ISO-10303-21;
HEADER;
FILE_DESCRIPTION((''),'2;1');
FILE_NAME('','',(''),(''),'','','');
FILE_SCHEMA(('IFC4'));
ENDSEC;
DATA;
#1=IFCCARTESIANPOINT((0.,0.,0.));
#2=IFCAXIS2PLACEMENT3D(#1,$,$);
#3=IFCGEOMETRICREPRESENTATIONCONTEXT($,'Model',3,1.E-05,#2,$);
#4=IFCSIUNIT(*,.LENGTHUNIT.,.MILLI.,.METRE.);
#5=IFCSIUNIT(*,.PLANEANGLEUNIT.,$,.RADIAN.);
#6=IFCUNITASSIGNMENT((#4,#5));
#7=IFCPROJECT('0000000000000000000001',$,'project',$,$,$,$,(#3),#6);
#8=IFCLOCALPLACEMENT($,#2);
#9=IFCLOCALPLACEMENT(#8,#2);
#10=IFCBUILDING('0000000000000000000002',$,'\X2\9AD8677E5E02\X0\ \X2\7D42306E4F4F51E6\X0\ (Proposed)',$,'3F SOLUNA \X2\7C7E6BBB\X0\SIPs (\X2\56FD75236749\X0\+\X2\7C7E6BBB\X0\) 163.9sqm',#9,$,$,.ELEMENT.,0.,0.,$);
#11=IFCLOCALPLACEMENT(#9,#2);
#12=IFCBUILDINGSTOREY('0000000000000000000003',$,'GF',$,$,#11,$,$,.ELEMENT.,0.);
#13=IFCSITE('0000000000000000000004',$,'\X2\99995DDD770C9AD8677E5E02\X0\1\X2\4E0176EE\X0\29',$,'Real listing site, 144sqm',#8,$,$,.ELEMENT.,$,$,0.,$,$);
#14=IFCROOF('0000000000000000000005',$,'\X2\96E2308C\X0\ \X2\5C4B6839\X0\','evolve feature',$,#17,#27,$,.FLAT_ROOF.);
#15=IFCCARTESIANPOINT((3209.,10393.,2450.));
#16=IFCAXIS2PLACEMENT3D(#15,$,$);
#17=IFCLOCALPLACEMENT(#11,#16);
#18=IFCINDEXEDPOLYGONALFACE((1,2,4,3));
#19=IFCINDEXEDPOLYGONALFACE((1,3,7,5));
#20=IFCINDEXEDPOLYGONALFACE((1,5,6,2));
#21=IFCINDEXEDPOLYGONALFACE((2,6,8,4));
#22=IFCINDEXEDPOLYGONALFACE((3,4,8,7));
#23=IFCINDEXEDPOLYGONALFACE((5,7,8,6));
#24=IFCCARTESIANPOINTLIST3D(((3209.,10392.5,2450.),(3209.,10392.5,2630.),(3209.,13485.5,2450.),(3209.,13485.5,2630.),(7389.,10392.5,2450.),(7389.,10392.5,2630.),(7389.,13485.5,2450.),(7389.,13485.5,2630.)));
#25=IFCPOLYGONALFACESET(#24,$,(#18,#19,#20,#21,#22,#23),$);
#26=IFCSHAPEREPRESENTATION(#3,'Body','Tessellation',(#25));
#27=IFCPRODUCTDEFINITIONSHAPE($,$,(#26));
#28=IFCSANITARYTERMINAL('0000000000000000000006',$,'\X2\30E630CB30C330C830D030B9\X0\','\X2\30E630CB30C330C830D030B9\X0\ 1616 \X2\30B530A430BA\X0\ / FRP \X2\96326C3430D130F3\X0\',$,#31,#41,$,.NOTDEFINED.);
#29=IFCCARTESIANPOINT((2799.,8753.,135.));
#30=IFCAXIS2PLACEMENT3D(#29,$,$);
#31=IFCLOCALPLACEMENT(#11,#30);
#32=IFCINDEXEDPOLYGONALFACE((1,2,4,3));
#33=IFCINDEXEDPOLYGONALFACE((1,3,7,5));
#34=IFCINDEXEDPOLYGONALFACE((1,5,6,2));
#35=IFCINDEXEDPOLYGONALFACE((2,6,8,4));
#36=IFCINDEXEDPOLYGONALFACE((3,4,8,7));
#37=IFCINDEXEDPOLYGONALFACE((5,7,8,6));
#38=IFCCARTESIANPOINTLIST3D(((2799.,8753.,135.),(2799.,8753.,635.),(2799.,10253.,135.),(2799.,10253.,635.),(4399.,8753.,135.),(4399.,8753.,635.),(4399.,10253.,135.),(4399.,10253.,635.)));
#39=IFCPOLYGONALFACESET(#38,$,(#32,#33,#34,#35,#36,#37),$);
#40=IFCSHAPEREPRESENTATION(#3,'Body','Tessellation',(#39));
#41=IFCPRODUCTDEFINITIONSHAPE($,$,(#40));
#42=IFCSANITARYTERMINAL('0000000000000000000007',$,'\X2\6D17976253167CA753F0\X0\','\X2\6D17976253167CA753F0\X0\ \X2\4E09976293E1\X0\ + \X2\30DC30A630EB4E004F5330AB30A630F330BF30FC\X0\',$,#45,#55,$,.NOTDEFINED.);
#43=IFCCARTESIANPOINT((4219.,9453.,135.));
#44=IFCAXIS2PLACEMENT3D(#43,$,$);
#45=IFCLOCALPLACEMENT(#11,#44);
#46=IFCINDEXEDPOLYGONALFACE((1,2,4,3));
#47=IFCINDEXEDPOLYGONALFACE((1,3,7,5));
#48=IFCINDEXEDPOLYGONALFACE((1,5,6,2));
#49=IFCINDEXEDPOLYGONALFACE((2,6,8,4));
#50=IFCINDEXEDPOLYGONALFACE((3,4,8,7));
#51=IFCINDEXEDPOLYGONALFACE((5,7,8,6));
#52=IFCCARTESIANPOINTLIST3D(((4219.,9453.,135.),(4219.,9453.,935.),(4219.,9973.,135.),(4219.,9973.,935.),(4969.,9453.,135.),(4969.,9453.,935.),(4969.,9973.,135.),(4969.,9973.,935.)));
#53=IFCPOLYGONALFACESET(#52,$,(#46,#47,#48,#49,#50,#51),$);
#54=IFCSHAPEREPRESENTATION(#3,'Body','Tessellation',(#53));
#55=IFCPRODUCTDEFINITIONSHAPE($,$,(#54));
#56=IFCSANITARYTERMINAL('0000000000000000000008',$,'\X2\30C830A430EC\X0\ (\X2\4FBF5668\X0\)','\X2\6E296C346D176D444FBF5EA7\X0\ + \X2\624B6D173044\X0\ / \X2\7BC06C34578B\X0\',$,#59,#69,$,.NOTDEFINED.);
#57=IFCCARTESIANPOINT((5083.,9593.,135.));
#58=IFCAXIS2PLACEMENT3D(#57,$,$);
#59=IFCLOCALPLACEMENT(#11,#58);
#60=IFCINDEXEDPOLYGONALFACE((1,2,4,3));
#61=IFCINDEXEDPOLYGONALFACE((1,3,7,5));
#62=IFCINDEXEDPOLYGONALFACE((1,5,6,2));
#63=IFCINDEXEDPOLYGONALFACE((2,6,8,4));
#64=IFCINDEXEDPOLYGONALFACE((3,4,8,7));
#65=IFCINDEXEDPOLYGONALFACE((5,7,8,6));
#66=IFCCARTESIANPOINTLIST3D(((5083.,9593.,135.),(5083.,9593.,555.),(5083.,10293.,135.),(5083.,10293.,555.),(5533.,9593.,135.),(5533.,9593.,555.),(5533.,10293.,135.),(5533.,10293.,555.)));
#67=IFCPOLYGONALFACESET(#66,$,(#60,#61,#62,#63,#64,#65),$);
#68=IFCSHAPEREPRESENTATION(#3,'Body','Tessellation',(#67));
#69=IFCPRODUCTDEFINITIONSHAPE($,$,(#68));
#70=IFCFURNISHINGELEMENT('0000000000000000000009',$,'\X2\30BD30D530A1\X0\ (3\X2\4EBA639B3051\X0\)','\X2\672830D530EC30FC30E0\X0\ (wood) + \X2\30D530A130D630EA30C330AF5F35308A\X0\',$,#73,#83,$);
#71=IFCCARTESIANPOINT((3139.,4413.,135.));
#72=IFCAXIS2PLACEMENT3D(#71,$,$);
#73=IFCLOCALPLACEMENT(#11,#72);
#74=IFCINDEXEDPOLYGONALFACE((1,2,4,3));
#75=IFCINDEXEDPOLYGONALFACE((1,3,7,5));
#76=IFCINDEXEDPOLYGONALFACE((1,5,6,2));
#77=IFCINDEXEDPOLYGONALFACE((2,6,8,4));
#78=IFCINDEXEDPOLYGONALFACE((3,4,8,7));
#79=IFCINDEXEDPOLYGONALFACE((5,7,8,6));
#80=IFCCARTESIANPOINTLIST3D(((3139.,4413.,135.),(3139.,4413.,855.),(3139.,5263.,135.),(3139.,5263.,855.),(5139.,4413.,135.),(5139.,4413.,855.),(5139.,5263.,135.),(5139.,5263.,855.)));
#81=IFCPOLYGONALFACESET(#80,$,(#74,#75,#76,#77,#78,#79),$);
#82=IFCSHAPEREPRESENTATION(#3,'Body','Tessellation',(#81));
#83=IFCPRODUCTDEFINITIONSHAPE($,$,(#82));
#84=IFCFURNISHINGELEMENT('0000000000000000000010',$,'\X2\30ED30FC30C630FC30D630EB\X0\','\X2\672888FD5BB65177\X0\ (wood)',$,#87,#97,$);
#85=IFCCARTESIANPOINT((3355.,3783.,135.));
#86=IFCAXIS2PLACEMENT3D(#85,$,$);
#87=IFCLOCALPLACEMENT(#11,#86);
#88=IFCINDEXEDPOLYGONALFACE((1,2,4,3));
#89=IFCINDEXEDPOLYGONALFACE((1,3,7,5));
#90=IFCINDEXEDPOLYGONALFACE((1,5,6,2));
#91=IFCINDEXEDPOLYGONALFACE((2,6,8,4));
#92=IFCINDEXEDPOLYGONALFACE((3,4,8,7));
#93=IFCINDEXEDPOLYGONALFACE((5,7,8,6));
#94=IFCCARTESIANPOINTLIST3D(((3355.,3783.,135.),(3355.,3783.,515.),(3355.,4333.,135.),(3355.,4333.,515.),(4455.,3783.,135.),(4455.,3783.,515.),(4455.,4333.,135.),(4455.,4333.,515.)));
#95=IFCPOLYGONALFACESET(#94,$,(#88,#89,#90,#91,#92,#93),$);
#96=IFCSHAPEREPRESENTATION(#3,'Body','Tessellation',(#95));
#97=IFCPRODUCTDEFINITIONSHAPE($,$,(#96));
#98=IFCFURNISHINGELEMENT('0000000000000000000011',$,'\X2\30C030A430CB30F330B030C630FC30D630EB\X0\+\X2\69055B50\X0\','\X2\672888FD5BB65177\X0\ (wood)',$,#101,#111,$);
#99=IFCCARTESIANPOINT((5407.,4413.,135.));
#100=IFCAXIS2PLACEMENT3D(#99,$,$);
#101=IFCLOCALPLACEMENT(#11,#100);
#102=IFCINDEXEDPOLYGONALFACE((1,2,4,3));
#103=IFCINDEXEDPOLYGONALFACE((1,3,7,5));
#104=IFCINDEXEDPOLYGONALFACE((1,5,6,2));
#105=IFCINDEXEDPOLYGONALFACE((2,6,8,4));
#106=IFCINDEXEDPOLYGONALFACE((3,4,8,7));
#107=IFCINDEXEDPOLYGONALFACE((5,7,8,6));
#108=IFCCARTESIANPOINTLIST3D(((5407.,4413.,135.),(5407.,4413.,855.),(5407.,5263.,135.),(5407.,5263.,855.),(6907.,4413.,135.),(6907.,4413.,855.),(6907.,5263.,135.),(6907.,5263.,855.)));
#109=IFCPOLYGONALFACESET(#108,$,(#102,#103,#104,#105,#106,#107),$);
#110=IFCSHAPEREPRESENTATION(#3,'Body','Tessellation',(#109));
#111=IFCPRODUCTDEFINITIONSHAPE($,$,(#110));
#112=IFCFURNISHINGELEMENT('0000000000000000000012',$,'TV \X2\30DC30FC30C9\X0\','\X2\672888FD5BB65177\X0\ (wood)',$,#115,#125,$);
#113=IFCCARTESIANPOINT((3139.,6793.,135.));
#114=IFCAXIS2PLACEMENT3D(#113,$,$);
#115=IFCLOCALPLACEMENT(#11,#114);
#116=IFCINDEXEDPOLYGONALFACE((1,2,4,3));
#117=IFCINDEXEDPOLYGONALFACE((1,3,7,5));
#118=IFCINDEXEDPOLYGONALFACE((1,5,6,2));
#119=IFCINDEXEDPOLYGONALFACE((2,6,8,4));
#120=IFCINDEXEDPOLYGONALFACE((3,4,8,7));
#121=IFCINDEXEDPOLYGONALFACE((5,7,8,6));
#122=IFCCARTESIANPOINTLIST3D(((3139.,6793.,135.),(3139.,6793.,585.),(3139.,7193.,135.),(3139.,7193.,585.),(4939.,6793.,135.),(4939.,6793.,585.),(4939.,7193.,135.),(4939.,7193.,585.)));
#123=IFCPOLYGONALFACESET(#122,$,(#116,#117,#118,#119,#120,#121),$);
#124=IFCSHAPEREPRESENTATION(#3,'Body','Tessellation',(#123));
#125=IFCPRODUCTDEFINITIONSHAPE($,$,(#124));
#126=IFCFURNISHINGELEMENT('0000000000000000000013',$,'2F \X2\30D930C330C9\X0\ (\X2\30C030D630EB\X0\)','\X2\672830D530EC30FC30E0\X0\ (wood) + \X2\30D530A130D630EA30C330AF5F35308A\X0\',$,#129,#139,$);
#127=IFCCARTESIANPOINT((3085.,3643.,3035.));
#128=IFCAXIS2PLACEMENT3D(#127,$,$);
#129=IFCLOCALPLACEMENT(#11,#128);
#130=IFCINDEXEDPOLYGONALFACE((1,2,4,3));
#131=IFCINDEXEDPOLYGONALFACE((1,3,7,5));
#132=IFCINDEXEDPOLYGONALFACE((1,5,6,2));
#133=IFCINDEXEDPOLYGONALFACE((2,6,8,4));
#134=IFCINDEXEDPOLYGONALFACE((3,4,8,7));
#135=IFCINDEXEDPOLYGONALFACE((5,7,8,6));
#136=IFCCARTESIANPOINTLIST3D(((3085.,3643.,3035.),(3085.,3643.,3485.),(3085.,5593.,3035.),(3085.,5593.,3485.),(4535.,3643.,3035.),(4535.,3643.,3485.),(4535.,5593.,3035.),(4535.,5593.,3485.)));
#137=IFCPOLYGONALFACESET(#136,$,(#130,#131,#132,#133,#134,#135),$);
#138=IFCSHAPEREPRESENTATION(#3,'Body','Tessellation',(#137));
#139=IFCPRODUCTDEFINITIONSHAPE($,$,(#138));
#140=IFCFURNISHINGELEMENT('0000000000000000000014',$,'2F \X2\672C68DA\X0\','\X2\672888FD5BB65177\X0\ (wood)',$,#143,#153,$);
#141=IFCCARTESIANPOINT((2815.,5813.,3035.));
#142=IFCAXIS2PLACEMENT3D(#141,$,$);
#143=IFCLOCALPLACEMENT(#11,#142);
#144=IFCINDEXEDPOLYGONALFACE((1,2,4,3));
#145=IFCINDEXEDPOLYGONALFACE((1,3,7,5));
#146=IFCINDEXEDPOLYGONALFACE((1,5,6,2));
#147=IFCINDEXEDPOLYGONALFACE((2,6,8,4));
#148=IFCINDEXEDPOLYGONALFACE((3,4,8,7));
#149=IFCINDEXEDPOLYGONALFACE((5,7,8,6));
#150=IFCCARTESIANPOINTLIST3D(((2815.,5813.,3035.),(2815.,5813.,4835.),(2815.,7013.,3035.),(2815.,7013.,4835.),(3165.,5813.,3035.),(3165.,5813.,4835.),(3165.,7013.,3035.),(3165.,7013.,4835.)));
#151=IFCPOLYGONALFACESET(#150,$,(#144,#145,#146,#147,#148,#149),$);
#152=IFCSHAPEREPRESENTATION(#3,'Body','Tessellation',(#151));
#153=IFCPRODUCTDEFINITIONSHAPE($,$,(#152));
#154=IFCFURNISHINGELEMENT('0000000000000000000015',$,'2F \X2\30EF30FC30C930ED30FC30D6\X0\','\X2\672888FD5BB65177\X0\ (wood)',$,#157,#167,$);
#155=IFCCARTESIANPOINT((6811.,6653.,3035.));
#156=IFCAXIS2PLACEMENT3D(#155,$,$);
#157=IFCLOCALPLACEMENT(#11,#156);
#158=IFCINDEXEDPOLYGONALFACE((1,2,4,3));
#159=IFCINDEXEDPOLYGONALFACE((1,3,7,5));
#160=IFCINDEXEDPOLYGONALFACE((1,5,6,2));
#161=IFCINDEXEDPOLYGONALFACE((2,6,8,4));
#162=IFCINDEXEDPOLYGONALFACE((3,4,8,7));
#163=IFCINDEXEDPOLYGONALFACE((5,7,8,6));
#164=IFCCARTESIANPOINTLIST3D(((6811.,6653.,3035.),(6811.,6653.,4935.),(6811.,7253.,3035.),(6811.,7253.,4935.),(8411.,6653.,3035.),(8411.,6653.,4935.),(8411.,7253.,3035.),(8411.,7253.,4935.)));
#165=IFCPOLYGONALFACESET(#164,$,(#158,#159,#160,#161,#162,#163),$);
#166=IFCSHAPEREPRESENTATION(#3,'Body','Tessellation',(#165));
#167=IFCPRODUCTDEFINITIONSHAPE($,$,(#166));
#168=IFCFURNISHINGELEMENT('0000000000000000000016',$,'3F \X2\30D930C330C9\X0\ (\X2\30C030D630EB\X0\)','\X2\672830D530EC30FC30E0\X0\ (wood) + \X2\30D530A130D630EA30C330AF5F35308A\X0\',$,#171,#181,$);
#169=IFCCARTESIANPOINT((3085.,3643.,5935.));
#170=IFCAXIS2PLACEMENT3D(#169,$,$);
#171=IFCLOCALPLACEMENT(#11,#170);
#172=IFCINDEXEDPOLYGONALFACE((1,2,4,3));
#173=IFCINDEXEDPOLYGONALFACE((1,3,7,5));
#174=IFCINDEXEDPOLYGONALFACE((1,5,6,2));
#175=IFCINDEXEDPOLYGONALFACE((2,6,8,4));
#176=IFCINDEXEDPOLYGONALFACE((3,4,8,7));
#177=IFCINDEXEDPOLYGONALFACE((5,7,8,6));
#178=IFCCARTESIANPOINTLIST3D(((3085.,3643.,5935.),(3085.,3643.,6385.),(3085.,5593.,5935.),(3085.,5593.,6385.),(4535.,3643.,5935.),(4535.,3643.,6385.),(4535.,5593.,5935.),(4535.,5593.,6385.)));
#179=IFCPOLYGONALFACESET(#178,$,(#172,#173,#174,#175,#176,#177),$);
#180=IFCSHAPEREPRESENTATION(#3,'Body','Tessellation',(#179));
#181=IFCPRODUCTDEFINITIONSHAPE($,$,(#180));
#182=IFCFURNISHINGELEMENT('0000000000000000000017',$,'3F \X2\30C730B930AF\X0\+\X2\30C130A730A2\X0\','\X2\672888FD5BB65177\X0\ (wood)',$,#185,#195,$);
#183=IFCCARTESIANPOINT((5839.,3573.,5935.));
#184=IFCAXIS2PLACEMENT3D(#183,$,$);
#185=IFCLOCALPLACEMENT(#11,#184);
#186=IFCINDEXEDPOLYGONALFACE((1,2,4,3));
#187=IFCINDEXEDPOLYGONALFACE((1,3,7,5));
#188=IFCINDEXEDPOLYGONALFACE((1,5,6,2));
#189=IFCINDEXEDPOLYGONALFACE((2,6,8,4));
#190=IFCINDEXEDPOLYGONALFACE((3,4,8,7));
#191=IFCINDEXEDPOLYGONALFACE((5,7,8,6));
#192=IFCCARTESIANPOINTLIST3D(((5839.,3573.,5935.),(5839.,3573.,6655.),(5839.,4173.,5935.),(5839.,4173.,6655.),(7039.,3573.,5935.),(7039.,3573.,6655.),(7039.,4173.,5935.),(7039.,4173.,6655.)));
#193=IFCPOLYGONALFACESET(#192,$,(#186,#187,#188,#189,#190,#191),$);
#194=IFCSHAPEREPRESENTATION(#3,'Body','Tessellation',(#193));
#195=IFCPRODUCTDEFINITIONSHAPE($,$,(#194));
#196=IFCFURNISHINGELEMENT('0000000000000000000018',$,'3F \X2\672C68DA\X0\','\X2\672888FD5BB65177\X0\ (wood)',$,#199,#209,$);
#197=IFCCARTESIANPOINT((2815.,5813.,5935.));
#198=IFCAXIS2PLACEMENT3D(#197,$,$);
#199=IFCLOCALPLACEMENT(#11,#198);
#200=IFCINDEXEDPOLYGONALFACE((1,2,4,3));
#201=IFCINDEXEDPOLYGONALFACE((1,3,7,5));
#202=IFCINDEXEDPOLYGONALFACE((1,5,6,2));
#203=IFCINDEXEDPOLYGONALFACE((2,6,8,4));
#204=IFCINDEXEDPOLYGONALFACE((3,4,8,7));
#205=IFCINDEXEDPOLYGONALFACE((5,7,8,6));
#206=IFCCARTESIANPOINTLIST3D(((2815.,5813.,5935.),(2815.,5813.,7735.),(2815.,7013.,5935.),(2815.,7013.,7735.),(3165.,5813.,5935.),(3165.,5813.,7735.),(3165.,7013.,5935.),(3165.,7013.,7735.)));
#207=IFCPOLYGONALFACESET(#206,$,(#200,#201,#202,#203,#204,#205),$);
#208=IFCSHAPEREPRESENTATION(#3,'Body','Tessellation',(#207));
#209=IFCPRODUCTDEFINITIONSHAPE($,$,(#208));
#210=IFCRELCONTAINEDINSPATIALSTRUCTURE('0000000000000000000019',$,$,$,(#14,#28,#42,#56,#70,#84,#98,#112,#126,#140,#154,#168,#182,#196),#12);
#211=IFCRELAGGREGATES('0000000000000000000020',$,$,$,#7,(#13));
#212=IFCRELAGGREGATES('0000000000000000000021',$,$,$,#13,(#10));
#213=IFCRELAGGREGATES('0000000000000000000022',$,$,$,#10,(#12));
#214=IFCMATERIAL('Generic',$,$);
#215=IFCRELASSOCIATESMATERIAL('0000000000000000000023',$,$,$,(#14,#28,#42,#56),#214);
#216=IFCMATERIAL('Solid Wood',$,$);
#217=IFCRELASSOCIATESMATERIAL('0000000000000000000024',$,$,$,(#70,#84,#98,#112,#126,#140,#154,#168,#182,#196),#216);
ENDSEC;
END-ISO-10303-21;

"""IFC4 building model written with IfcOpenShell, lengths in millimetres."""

from ifc_helpers import new_model, si_unit, frame, frame_2d, origin, place, context, project, spatial, rectangle, extrude, material, element, save


model = new_model("IFC4")

# Units and contexts
model_context = context("Model", 3, precision=1e-05, world=origin())
ifc_project = project(units=[si_unit("LENGTHUNIT", "METRE", prefix="MILLI"), si_unit("PLANEANGLEUNIT", "RADIAN")], contexts=[model_context])

# Site, building, storey
site_placement = place(None, origin())
site = spatial("IfcSite", under=ifc_project, at=site_placement, Name="香川県高松市1丁目29", ObjectType="Real listing site, 144sqm", CompositionType="ELEMENT", RefElevation=0.0)
building_placement = place(site_placement, origin())
building = spatial("IfcBuilding", under=site, at=building_placement, Name="高松市 終の住処 (Proposed)", ObjectType="3F SOLUNA 籾殻SIPs (国産杉+籾殻) 163.9sqm", CompositionType="ELEMENT", ElevationOfRefHeight=0.0, ElevationOfTerrain=0.0)
storey_placement = place(building_placement, origin())
storey = spatial("IfcBuildingStorey", under=building, at=storey_placement, Name="GF", CompositionType="ELEMENT", Elevation=0.0)

# Shared definitions
ifc_material_1 = material(Name="Generic")

# Shared definitions
ifc_material_2 = material(Name="Solid Wood")

# Roof
roof_placement = place(storey_placement, frame((3209.0, 10393.0, 2450.0)))
element("IfcRoof", 1, at=roof_placement, inside=storey, material=ifc_material_1, Name="離れ 屋根", Description="evolve feature", PredefinedType="FLAT_ROOF", context=model_context, shape_type="SweptSolid", body=[
    extrude(rectangle(XDim=4180.0, YDim=3093.0, at=frame_2d((2090.0, 1546.0))), frame((3209.0, 10393.0, 2450.0)), (0.0, 0.0, 1.0), 180.0),
])

# Sanitary terminals
sanitary_terminal_1_placement = place(storey_placement, frame((2799.0, 8753.0, 135.0)))
element("IfcSanitaryTerminal", 2, at=sanitary_terminal_1_placement, inside=storey, material=ifc_material_1, Name="ユニットバス", Description="ユニットバス 1616 サイズ / FRP 防水パン", PredefinedType="NOTDEFINED", context=model_context, shape_type="SweptSolid", body=[
    extrude(rectangle(XDim=1600.0, YDim=1500.0, at=frame_2d((800.0, 750.0))), frame((2799.0, 8753.0, 135.0)), (0.0, 0.0, 1.0), 500.0),
])
sanitary_terminal_2_placement = place(storey_placement, frame((4219.0, 9453.0, 135.0)))
element("IfcSanitaryTerminal", 3, at=sanitary_terminal_2_placement, inside=storey, material=ifc_material_1, Name="洗面化粧台", Description="洗面化粧台 三面鏡 + ボウル一体カウンター", PredefinedType="NOTDEFINED", context=model_context, shape_type="SweptSolid", body=[
    extrude(rectangle(XDim=750.0, YDim=520.0, at=frame_2d((375.0, 260.0))), frame((4219.0, 9453.0, 135.0)), (0.0, 0.0, 1.0), 800.0),
])
sanitary_terminal_3_placement = place(storey_placement, frame((5083.0, 9593.0, 135.0)))
element("IfcSanitaryTerminal", 4, at=sanitary_terminal_3_placement, inside=storey, material=ifc_material_1, Name="トイレ (便器)", Description="温水洗浄便座 + 手洗い / 節水型", PredefinedType="NOTDEFINED", context=model_context, shape_type="SweptSolid", body=[
    extrude(rectangle(XDim=450.0, YDim=700.0, at=frame_2d((225.0, 350.0))), frame((5083.0, 9593.0, 135.0)), (0.0, 0.0, 1.0), 420.0),
])

# Furnishing elements
furnishing_1_placement = place(storey_placement, frame((3139.0, 4413.0, 135.0)))
element("IfcFurnishingElement", 5, at=furnishing_1_placement, inside=storey, material=ifc_material_2, Name="ソファ (3人掛け)", Description="木フレーム (wood) + ファブリック張り", context=model_context, shape_type="SweptSolid", body=[
    extrude(rectangle(XDim=2000.0, YDim=850.0, at=frame_2d((1000.0, 425.0))), frame((3139.0, 4413.0, 135.0)), (0.0, 0.0, 1.0), 720.0),
])
furnishing_2_placement = place(storey_placement, frame((3355.0, 3783.0, 135.0)))
element("IfcFurnishingElement", 6, at=furnishing_2_placement, inside=storey, material=ifc_material_2, Name="ローテーブル", Description="木製家具 (wood)", context=model_context, shape_type="SweptSolid", body=[
    extrude(rectangle(XDim=1100.0, YDim=550.0, at=frame_2d((550.0, 275.0))), frame((3355.0, 3783.0, 135.0)), (0.0, 0.0, 1.0), 380.0),
])
furnishing_3_placement = place(storey_placement, frame((5407.0, 4413.0, 135.0)))
element("IfcFurnishingElement", 7, at=furnishing_3_placement, inside=storey, material=ifc_material_2, Name="ダイニングテーブル+椅子", Description="木製家具 (wood)", context=model_context, shape_type="SweptSolid", body=[
    extrude(rectangle(XDim=1500.0, YDim=850.0, at=frame_2d((750.0, 425.0))), frame((5407.0, 4413.0, 135.0)), (0.0, 0.0, 1.0), 720.0),
])
furnishing_4_placement = place(storey_placement, frame((3139.0, 6793.0, 135.0)))
element("IfcFurnishingElement", 8, at=furnishing_4_placement, inside=storey, material=ifc_material_2, Name="TV ボード", Description="木製家具 (wood)", context=model_context, shape_type="SweptSolid", body=[
    extrude(rectangle(XDim=1800.0, YDim=400.0, at=frame_2d((900.0, 200.0))), frame((3139.0, 6793.0, 135.0)), (0.0, 0.0, 1.0), 450.0),
])
furnishing_5_placement = place(storey_placement, frame((3085.0, 3643.0, 3035.0)))
element("IfcFurnishingElement", 9, at=furnishing_5_placement, inside=storey, material=ifc_material_2, Name="2F ベッド (ダブル)", Description="木フレーム (wood) + ファブリック張り", context=model_context, shape_type="SweptSolid", body=[
    extrude(rectangle(XDim=1450.0, YDim=1950.0, at=frame_2d((725.0, 975.0))), frame((3085.0, 3643.0, 3035.0)), (0.0, 0.0, 1.0), 450.0),
])
furnishing_6_placement = place(storey_placement, frame((2815.0, 5813.0, 3035.0)))
element("IfcFurnishingElement", 10, at=furnishing_6_placement, inside=storey, material=ifc_material_2, Name="2F 本棚", Description="木製家具 (wood)", context=model_context, shape_type="SweptSolid", body=[
    extrude(rectangle(XDim=350.0, YDim=1200.0, at=frame_2d((175.0, 600.0))), frame((2815.0, 5813.0, 3035.0)), (0.0, 0.0, 1.0), 1800.0),
])
furnishing_7_placement = place(storey_placement, frame((6811.0, 6653.0, 3035.0)))
element("IfcFurnishingElement", 11, at=furnishing_7_placement, inside=storey, material=ifc_material_2, Name="2F ワードローブ", Description="木製家具 (wood)", context=model_context, shape_type="SweptSolid", body=[
    extrude(rectangle(XDim=1600.0, YDim=600.0, at=frame_2d((800.0, 300.0))), frame((6811.0, 6653.0, 3035.0)), (0.0, 0.0, 1.0), 1900.0),
])
furnishing_8_placement = place(storey_placement, frame((3085.0, 3643.0, 5935.0)))
element("IfcFurnishingElement", 12, at=furnishing_8_placement, inside=storey, material=ifc_material_2, Name="3F ベッド (ダブル)", Description="木フレーム (wood) + ファブリック張り", context=model_context, shape_type="SweptSolid", body=[
    extrude(rectangle(XDim=1450.0, YDim=1950.0, at=frame_2d((725.0, 975.0))), frame((3085.0, 3643.0, 5935.0)), (0.0, 0.0, 1.0), 450.0),
])
furnishing_9_placement = place(storey_placement, frame((5839.0, 3573.0, 5935.0)))
element("IfcFurnishingElement", 13, at=furnishing_9_placement, inside=storey, material=ifc_material_2, Name="3F デスク+チェア", Description="木製家具 (wood)", context=model_context, shape_type="SweptSolid", body=[
    extrude(rectangle(XDim=1200.0, YDim=600.0, at=frame_2d((600.0, 300.0))), frame((5839.0, 3573.0, 5935.0)), (0.0, 0.0, 1.0), 720.0),
])
furnishing_10_placement = place(storey_placement, frame((2815.0, 5813.0, 5935.0)))
element("IfcFurnishingElement", 14, at=furnishing_10_placement, inside=storey, material=ifc_material_2, Name="3F 本棚", Description="木製家具 (wood)", context=model_context, shape_type="SweptSolid", body=[
    extrude(rectangle(XDim=350.0, YDim=1200.0, at=frame_2d((175.0, 600.0))), frame((2815.0, 5813.0, 5935.0)), (0.0, 0.0, 1.0), 1800.0),
])

save(model, "model.ifc")
